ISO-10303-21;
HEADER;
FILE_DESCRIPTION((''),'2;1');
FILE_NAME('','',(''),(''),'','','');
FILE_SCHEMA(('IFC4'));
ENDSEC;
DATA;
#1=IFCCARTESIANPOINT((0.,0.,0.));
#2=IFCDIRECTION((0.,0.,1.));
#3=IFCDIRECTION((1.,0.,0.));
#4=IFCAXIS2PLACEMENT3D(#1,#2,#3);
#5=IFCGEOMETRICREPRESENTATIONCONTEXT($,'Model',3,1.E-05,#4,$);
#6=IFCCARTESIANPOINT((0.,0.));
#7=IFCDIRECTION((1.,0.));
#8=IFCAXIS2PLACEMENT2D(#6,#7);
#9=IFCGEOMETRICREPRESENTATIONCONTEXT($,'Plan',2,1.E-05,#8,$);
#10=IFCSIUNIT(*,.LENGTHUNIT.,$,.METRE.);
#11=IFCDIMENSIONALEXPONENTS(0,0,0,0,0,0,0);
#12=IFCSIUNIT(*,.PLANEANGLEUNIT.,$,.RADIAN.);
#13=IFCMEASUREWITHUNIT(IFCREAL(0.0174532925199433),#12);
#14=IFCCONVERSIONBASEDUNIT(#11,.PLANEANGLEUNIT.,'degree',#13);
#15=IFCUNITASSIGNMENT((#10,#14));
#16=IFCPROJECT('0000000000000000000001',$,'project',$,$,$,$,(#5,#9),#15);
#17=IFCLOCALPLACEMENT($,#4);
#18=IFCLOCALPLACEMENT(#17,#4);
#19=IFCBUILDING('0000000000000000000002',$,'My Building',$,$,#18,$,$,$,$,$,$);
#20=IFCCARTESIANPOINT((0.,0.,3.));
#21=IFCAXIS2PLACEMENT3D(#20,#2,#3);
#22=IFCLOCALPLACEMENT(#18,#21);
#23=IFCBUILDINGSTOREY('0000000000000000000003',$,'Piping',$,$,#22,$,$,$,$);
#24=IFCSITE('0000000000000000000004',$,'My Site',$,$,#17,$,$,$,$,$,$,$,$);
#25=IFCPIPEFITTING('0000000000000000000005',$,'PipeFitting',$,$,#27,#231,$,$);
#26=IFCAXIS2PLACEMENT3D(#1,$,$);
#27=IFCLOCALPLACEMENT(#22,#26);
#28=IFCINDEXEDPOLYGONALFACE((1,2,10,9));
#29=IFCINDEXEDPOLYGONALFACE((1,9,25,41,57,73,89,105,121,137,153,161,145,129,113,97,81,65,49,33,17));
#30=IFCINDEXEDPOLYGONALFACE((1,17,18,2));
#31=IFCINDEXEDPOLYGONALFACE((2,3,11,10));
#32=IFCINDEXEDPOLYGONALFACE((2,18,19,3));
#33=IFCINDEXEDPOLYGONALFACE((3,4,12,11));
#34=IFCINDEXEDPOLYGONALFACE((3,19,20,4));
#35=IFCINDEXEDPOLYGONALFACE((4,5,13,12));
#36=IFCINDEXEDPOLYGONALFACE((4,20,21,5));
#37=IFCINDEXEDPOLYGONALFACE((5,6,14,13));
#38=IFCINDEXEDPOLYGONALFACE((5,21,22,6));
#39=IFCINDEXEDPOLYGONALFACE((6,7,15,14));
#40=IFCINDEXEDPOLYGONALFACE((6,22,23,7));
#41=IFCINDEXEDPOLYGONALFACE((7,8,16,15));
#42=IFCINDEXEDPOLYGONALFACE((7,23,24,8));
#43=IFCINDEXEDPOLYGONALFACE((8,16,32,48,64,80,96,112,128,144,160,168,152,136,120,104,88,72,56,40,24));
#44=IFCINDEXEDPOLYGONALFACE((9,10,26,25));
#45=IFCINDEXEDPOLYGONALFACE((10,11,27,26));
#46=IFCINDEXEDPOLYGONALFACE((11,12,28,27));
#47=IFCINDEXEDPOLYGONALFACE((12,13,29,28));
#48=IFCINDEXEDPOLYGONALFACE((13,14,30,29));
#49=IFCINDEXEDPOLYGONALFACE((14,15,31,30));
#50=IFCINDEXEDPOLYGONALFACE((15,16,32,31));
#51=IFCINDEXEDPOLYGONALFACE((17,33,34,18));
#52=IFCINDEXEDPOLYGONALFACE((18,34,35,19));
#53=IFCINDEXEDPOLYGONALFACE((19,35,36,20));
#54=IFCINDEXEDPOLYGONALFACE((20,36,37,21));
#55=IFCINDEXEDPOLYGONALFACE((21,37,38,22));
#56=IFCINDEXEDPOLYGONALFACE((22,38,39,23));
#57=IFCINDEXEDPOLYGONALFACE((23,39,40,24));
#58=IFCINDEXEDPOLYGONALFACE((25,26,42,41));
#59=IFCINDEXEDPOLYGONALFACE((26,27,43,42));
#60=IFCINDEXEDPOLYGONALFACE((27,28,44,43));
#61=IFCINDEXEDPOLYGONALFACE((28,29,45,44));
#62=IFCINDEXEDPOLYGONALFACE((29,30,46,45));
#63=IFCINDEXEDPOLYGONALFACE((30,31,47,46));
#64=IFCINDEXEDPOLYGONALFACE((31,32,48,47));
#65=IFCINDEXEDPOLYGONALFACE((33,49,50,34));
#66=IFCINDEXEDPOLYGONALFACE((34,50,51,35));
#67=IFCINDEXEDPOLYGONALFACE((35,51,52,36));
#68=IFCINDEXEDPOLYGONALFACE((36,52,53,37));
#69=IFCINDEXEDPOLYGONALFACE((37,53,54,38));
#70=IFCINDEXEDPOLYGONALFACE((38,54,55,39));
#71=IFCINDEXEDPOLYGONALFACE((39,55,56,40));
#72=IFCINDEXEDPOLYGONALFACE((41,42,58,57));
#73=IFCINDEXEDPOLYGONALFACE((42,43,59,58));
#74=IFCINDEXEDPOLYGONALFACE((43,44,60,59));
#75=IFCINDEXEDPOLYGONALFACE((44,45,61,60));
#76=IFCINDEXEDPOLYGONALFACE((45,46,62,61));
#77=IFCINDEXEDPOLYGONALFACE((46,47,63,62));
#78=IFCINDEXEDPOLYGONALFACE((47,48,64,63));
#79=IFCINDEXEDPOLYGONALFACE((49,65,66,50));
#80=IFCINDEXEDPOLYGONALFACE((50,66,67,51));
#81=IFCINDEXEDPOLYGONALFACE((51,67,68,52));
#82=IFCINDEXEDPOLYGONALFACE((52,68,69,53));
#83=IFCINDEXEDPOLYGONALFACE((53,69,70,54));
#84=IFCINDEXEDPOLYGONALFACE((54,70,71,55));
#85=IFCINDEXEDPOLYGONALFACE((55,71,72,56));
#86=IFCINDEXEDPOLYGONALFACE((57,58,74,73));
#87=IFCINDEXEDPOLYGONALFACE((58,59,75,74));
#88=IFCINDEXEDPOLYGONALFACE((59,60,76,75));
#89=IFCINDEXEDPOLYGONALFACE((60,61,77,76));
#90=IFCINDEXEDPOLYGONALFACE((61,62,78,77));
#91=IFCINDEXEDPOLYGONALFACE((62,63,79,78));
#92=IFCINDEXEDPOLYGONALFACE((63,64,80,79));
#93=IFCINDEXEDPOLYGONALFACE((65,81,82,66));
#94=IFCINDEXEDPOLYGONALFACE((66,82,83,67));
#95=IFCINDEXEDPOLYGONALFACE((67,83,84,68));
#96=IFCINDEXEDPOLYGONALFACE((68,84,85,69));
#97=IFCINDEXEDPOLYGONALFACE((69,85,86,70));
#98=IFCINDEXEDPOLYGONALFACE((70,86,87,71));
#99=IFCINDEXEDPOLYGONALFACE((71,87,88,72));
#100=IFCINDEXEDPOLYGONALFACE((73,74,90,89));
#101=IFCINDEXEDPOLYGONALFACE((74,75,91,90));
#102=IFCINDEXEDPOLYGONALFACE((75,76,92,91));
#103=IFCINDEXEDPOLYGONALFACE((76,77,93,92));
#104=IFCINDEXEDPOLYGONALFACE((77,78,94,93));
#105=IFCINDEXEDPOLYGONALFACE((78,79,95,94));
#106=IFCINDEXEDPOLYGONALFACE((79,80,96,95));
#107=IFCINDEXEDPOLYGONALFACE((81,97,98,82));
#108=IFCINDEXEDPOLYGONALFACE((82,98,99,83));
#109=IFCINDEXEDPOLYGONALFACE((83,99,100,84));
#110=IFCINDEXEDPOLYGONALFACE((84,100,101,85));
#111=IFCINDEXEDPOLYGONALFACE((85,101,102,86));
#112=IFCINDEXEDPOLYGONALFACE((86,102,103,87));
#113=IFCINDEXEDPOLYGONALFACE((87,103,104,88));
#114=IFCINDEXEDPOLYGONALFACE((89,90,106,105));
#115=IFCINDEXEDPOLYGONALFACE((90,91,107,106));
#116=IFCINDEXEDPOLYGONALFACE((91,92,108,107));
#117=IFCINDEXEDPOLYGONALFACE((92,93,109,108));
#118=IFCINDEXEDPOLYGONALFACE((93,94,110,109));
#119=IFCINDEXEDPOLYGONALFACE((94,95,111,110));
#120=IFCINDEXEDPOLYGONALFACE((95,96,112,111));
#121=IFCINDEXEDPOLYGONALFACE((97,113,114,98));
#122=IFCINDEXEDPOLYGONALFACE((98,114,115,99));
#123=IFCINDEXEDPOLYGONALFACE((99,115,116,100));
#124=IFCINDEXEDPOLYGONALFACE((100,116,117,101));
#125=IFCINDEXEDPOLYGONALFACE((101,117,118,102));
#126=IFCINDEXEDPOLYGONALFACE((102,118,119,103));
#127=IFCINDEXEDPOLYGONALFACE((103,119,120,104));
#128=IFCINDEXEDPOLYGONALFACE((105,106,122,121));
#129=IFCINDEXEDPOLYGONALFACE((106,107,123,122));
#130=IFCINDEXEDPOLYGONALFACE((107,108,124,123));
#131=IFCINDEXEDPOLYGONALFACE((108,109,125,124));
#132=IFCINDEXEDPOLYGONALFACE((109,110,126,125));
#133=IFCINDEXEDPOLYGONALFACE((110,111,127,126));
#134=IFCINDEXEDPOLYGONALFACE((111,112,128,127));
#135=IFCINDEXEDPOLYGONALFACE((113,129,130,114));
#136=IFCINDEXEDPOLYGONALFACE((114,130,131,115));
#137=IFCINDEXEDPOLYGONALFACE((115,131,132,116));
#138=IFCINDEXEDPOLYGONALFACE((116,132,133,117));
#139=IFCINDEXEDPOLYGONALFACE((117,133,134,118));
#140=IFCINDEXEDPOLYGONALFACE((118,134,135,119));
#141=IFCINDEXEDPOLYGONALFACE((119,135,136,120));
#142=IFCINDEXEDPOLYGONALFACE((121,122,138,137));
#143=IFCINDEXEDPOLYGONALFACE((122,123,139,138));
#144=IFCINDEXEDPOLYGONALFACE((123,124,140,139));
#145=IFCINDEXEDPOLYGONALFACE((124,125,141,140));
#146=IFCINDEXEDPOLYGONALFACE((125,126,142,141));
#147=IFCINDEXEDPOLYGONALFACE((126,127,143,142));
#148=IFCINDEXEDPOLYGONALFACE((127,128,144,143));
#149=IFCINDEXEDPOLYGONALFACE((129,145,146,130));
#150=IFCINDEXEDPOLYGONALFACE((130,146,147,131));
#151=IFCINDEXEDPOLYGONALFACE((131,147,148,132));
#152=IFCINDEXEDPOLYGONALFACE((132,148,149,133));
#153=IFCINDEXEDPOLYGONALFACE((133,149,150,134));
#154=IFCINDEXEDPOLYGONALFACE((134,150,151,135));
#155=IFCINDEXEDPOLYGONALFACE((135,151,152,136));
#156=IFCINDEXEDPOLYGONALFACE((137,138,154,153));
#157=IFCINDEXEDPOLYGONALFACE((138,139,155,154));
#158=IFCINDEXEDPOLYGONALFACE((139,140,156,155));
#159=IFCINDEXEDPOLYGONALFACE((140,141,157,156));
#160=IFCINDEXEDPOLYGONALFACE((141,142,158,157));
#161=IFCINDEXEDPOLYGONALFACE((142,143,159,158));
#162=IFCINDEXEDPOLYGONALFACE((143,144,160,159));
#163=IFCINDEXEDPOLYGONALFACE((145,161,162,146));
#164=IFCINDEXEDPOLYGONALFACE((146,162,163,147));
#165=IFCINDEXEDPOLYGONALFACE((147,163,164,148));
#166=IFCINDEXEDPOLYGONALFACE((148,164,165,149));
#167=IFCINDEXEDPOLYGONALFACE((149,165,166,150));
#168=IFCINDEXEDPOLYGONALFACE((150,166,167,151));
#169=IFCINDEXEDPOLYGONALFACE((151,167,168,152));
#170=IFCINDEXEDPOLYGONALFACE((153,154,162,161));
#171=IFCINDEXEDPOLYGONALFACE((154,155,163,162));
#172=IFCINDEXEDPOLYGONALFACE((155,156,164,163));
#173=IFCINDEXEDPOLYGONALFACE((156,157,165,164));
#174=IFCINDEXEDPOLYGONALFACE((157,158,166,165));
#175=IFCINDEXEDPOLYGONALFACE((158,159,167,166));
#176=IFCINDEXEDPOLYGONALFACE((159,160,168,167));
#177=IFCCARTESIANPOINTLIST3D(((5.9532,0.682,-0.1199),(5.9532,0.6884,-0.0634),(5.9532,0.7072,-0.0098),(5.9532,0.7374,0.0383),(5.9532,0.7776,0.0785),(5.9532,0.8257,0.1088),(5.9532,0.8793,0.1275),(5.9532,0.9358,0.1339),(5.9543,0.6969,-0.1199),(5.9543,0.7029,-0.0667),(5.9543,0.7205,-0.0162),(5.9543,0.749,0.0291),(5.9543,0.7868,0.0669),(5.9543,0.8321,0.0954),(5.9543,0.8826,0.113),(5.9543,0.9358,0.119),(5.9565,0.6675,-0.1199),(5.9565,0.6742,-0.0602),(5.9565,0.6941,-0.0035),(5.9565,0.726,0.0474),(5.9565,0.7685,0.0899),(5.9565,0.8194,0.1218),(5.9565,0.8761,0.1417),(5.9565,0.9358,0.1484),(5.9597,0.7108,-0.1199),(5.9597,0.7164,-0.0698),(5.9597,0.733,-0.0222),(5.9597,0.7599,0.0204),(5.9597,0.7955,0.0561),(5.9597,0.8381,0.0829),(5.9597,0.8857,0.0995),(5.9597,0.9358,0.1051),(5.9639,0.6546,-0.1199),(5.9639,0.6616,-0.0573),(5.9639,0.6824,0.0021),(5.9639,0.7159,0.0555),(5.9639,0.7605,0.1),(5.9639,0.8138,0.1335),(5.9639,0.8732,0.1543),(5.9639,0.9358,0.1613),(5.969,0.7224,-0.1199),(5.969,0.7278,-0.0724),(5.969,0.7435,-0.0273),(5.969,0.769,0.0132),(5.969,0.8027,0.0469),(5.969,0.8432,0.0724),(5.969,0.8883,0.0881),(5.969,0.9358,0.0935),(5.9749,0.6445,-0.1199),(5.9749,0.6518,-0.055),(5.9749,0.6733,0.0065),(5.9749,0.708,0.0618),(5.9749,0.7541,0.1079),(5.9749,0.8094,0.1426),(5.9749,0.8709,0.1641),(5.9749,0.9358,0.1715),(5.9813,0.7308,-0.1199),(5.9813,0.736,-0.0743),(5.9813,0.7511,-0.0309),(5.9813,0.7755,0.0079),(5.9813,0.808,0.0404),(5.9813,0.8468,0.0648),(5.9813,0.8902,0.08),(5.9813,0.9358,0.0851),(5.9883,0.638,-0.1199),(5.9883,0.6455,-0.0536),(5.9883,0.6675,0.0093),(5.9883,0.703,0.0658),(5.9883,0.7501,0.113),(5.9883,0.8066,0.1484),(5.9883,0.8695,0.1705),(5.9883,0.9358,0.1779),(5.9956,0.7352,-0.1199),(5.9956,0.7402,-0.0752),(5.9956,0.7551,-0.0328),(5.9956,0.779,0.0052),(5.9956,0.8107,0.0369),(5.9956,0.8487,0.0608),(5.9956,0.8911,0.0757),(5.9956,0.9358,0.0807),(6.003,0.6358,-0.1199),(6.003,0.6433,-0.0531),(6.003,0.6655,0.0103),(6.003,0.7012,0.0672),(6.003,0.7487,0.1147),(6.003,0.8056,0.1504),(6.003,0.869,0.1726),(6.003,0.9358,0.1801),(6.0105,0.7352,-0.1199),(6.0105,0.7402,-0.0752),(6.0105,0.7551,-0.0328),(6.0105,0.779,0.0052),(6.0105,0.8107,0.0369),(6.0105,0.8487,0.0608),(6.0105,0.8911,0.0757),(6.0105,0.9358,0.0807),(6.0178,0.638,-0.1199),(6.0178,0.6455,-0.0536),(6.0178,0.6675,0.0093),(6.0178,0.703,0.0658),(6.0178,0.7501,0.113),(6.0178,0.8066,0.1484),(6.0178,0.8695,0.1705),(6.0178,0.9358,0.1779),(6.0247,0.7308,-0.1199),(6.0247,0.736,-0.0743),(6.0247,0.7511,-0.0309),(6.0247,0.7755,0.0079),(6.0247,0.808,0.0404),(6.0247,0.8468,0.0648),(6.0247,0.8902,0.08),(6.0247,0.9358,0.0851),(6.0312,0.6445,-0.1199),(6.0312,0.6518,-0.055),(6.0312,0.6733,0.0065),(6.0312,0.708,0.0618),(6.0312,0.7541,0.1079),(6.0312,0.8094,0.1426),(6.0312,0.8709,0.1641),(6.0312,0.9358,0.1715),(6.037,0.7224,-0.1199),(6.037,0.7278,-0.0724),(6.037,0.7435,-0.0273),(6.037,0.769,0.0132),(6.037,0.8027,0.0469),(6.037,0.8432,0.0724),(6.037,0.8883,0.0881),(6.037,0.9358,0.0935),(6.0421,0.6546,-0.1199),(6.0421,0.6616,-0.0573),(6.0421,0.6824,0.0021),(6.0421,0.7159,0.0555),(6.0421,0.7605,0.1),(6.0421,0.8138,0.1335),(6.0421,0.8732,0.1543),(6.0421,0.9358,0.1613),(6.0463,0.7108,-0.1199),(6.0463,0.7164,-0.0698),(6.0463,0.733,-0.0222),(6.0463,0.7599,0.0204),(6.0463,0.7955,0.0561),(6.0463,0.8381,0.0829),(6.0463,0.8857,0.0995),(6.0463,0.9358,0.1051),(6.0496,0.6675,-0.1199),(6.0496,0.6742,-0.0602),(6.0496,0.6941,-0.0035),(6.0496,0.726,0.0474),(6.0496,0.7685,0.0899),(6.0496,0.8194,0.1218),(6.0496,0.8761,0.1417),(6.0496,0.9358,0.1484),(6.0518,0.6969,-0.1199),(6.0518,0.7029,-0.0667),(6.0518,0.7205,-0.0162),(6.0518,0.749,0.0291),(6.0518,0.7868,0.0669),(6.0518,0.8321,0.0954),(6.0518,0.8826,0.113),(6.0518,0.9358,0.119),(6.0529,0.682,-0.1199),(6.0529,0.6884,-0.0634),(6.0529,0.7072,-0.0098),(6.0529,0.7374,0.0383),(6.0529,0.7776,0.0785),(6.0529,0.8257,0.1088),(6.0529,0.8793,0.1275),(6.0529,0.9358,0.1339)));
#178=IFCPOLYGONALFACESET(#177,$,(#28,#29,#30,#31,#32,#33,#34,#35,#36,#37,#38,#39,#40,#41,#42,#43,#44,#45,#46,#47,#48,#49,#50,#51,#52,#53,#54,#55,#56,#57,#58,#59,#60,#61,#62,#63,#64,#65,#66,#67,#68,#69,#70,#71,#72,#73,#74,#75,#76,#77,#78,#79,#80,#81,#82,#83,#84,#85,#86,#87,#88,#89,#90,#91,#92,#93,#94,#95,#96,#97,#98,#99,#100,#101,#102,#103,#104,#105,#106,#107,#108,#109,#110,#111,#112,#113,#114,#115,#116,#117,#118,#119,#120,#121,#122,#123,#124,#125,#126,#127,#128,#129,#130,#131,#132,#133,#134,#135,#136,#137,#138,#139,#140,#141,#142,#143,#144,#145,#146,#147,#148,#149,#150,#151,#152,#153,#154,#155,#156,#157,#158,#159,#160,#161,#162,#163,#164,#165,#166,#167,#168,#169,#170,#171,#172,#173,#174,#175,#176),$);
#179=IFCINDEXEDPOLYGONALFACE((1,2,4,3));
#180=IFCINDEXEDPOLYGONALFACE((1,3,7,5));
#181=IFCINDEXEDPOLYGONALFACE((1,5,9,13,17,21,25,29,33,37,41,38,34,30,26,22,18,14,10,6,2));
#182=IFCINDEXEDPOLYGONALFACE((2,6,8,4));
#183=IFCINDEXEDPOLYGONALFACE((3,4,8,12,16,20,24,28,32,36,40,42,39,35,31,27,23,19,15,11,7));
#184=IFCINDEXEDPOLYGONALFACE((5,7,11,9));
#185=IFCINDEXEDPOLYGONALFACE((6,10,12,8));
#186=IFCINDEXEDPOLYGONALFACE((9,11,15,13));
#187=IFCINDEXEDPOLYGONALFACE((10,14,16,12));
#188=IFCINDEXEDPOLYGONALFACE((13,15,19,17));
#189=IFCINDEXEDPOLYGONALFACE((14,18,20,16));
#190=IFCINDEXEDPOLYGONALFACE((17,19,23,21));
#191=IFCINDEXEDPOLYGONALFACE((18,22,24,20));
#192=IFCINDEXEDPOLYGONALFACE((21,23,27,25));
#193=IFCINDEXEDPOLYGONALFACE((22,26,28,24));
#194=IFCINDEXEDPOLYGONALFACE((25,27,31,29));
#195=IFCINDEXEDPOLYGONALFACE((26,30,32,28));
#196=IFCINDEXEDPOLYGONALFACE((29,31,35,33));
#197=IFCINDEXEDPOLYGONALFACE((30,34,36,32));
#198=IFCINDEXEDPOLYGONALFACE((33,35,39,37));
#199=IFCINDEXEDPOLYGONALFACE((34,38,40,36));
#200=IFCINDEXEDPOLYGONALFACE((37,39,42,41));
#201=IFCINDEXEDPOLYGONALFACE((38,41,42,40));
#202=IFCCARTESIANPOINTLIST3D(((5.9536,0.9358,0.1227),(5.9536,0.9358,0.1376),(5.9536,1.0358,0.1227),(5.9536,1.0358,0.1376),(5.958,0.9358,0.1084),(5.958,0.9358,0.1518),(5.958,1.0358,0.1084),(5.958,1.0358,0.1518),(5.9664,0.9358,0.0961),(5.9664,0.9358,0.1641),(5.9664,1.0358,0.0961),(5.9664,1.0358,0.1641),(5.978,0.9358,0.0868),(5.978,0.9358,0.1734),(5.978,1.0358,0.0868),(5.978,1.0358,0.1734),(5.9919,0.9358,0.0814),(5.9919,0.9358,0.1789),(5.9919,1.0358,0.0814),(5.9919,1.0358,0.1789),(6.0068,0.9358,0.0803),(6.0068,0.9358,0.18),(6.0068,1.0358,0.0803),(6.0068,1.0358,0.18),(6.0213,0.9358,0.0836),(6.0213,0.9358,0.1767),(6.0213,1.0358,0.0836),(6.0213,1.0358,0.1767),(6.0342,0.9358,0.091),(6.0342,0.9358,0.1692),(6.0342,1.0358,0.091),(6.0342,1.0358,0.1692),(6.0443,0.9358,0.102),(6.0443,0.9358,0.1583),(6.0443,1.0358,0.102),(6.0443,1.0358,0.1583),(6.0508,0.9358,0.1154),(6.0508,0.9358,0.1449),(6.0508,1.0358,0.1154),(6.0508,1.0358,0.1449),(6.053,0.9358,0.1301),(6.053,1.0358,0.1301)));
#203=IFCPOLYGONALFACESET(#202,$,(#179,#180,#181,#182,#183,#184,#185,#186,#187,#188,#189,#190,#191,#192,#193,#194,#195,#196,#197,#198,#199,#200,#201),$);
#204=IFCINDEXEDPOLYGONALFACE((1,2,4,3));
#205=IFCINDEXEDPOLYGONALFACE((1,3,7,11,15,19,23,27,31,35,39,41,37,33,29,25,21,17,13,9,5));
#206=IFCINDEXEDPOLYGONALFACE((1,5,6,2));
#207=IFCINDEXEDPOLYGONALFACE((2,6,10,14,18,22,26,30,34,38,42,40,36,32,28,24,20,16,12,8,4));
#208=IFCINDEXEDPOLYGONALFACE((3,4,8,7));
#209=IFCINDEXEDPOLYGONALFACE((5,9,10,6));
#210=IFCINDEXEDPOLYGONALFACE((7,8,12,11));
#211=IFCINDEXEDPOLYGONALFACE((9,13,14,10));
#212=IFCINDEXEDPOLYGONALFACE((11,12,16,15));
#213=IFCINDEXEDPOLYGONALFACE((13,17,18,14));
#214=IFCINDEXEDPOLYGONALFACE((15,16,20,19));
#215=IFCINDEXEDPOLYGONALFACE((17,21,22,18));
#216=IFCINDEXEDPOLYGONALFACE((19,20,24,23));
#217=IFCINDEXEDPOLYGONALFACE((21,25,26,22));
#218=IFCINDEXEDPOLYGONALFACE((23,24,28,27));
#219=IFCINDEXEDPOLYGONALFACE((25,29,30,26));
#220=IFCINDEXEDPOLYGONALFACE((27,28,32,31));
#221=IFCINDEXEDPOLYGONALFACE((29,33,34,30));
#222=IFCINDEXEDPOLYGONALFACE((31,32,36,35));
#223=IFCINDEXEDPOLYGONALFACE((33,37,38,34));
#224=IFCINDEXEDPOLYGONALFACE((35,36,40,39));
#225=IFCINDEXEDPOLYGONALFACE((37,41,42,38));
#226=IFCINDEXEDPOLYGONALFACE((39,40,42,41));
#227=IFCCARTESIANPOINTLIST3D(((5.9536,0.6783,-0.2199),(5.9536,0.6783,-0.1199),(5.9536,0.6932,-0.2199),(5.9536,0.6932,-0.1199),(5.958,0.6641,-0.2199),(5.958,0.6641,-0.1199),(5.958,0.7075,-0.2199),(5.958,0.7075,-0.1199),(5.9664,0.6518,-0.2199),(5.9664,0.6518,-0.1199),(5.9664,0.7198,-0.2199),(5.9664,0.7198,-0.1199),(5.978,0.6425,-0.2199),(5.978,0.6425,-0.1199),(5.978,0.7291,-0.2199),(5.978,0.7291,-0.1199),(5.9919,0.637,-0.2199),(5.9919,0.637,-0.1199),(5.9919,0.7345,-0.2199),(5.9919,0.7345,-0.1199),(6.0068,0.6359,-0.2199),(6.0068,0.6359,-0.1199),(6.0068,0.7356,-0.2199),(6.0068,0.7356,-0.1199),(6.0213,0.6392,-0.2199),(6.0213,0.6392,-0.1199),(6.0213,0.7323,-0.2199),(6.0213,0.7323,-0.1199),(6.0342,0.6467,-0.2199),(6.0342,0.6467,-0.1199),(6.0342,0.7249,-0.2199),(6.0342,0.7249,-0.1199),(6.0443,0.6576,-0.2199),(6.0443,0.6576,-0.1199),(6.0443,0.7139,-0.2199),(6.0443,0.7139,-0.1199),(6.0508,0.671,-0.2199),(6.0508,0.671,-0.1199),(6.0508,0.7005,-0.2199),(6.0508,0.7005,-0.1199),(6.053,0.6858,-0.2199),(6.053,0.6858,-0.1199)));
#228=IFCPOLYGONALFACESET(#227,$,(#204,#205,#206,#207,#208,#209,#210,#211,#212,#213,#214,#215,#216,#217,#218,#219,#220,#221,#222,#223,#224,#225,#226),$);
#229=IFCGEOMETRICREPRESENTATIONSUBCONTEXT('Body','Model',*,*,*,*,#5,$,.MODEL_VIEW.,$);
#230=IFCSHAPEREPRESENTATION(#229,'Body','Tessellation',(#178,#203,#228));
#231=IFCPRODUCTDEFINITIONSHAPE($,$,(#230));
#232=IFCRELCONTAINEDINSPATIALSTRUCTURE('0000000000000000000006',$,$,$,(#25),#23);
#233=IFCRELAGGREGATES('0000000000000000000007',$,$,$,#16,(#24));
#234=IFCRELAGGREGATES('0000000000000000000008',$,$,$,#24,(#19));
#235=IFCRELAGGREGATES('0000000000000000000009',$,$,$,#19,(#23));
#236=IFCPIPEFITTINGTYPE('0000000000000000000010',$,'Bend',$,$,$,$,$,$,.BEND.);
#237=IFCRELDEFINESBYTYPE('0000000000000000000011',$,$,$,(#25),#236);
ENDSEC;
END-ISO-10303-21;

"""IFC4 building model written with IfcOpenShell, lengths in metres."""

from ifc_helpers import new_model, entity, si_unit, converted_unit, frame, origin_with_axes, origin_2d_with_axis, place, context, subcontext, project, spatial, circle, extrude, source, transform, mapped, type_object, type_shapes, element, save


model = new_model("IFC4")

# Units and contexts
model_context = context("Model", 3, precision=1e-05, world=origin_with_axes())
plan_context = context("Plan", 2, precision=1e-05, world=origin_2d_with_axis())
body_context = subcontext(model_context, "Body", "Model", "MODEL_VIEW")
ifc_project = project(units=[si_unit("LENGTHUNIT", "METRE"), converted_unit("PLANEANGLEUNIT", "degree", entity("IfcReal", 0.0174532925199433), si_unit("PLANEANGLEUNIT", "RADIAN"), dimensions=[0, 0, 0, 0, 0, 0, 0])], contexts=[model_context, plan_context])

# Site, building, storey
site_placement = place(None, origin_with_axes())
site = spatial("IfcSite", under=ifc_project, at=site_placement, Name="My Site")
building_placement = place(site_placement, origin_with_axes())
building = spatial("IfcBuilding", under=site, at=building_placement, Name="My Building")
storey_placement = place(building_placement, frame((0.0, 0.0, 3.0), z_axis=(0.0, 0.0, 1.0), x_axis=(1.0, 0.0, 0.0)))
storey = spatial("IfcBuildingStorey", under=building, at=storey_placement, Name="Piping")

# Pipe fitting
pipe_fitting_type_1 = type_object("IfcPipeFittingType", Name="Bend", PredefinedType="BEND")
shared_shape_1 = source(origin_with_axes(), body_context, "Body", "SolidModel", [
    entity("IfcSweptDiskSolid", entity("IfcIndexedPolyCurve", entity("IfcCartesianPointList3D", [[0.0, 0.0, 0.1], [0.0, -0.0732, 0.2768], [0.0, -0.25, 0.35]]), [entity("IfcArcIndex", [1, 2, 3])]), 0.05),
    extrude(circle(Radius=0.05), origin_with_axes(), (0.0, 0.0, 1.0), 0.1),
    extrude(circle(Radius=0.05), frame((0.0, -0.25, 0.35), z_axis=(0.0, -1.0, -0.000015), x_axis=(1.0, 0.0, 0.0)), (0.0, 0.0, 1.0), 0.1),
])
type_shapes(pipe_fitting_type_1, [shared_shape_1])
for number, where, z_axis, x_axis, name in (
    (1, (6.003, 1.0358, 0.1301), (0.0, -1.0, 0.000015), (1.0, 0.0, 0.0), "PipeFitting"),
):
    element("IfcPipeFitting", number, at=place(storey_placement, frame(where, z_axis=z_axis, x_axis=x_axis)), inside=storey, type_object=pipe_fitting_type_1, Name=name, context=body_context, shape_type="MappedRepresentation", body=[
        mapped(shared_shape_1, transform((0.0, 0.0, 0.0), x_axis=(1.0, 0.0, 0.0), y_axis=(0.0, 1.0, 0.0), z_axis=(0.0, 0.0, 1.0), scale=1.0)),
    ])

save(model, "model.ifc")
